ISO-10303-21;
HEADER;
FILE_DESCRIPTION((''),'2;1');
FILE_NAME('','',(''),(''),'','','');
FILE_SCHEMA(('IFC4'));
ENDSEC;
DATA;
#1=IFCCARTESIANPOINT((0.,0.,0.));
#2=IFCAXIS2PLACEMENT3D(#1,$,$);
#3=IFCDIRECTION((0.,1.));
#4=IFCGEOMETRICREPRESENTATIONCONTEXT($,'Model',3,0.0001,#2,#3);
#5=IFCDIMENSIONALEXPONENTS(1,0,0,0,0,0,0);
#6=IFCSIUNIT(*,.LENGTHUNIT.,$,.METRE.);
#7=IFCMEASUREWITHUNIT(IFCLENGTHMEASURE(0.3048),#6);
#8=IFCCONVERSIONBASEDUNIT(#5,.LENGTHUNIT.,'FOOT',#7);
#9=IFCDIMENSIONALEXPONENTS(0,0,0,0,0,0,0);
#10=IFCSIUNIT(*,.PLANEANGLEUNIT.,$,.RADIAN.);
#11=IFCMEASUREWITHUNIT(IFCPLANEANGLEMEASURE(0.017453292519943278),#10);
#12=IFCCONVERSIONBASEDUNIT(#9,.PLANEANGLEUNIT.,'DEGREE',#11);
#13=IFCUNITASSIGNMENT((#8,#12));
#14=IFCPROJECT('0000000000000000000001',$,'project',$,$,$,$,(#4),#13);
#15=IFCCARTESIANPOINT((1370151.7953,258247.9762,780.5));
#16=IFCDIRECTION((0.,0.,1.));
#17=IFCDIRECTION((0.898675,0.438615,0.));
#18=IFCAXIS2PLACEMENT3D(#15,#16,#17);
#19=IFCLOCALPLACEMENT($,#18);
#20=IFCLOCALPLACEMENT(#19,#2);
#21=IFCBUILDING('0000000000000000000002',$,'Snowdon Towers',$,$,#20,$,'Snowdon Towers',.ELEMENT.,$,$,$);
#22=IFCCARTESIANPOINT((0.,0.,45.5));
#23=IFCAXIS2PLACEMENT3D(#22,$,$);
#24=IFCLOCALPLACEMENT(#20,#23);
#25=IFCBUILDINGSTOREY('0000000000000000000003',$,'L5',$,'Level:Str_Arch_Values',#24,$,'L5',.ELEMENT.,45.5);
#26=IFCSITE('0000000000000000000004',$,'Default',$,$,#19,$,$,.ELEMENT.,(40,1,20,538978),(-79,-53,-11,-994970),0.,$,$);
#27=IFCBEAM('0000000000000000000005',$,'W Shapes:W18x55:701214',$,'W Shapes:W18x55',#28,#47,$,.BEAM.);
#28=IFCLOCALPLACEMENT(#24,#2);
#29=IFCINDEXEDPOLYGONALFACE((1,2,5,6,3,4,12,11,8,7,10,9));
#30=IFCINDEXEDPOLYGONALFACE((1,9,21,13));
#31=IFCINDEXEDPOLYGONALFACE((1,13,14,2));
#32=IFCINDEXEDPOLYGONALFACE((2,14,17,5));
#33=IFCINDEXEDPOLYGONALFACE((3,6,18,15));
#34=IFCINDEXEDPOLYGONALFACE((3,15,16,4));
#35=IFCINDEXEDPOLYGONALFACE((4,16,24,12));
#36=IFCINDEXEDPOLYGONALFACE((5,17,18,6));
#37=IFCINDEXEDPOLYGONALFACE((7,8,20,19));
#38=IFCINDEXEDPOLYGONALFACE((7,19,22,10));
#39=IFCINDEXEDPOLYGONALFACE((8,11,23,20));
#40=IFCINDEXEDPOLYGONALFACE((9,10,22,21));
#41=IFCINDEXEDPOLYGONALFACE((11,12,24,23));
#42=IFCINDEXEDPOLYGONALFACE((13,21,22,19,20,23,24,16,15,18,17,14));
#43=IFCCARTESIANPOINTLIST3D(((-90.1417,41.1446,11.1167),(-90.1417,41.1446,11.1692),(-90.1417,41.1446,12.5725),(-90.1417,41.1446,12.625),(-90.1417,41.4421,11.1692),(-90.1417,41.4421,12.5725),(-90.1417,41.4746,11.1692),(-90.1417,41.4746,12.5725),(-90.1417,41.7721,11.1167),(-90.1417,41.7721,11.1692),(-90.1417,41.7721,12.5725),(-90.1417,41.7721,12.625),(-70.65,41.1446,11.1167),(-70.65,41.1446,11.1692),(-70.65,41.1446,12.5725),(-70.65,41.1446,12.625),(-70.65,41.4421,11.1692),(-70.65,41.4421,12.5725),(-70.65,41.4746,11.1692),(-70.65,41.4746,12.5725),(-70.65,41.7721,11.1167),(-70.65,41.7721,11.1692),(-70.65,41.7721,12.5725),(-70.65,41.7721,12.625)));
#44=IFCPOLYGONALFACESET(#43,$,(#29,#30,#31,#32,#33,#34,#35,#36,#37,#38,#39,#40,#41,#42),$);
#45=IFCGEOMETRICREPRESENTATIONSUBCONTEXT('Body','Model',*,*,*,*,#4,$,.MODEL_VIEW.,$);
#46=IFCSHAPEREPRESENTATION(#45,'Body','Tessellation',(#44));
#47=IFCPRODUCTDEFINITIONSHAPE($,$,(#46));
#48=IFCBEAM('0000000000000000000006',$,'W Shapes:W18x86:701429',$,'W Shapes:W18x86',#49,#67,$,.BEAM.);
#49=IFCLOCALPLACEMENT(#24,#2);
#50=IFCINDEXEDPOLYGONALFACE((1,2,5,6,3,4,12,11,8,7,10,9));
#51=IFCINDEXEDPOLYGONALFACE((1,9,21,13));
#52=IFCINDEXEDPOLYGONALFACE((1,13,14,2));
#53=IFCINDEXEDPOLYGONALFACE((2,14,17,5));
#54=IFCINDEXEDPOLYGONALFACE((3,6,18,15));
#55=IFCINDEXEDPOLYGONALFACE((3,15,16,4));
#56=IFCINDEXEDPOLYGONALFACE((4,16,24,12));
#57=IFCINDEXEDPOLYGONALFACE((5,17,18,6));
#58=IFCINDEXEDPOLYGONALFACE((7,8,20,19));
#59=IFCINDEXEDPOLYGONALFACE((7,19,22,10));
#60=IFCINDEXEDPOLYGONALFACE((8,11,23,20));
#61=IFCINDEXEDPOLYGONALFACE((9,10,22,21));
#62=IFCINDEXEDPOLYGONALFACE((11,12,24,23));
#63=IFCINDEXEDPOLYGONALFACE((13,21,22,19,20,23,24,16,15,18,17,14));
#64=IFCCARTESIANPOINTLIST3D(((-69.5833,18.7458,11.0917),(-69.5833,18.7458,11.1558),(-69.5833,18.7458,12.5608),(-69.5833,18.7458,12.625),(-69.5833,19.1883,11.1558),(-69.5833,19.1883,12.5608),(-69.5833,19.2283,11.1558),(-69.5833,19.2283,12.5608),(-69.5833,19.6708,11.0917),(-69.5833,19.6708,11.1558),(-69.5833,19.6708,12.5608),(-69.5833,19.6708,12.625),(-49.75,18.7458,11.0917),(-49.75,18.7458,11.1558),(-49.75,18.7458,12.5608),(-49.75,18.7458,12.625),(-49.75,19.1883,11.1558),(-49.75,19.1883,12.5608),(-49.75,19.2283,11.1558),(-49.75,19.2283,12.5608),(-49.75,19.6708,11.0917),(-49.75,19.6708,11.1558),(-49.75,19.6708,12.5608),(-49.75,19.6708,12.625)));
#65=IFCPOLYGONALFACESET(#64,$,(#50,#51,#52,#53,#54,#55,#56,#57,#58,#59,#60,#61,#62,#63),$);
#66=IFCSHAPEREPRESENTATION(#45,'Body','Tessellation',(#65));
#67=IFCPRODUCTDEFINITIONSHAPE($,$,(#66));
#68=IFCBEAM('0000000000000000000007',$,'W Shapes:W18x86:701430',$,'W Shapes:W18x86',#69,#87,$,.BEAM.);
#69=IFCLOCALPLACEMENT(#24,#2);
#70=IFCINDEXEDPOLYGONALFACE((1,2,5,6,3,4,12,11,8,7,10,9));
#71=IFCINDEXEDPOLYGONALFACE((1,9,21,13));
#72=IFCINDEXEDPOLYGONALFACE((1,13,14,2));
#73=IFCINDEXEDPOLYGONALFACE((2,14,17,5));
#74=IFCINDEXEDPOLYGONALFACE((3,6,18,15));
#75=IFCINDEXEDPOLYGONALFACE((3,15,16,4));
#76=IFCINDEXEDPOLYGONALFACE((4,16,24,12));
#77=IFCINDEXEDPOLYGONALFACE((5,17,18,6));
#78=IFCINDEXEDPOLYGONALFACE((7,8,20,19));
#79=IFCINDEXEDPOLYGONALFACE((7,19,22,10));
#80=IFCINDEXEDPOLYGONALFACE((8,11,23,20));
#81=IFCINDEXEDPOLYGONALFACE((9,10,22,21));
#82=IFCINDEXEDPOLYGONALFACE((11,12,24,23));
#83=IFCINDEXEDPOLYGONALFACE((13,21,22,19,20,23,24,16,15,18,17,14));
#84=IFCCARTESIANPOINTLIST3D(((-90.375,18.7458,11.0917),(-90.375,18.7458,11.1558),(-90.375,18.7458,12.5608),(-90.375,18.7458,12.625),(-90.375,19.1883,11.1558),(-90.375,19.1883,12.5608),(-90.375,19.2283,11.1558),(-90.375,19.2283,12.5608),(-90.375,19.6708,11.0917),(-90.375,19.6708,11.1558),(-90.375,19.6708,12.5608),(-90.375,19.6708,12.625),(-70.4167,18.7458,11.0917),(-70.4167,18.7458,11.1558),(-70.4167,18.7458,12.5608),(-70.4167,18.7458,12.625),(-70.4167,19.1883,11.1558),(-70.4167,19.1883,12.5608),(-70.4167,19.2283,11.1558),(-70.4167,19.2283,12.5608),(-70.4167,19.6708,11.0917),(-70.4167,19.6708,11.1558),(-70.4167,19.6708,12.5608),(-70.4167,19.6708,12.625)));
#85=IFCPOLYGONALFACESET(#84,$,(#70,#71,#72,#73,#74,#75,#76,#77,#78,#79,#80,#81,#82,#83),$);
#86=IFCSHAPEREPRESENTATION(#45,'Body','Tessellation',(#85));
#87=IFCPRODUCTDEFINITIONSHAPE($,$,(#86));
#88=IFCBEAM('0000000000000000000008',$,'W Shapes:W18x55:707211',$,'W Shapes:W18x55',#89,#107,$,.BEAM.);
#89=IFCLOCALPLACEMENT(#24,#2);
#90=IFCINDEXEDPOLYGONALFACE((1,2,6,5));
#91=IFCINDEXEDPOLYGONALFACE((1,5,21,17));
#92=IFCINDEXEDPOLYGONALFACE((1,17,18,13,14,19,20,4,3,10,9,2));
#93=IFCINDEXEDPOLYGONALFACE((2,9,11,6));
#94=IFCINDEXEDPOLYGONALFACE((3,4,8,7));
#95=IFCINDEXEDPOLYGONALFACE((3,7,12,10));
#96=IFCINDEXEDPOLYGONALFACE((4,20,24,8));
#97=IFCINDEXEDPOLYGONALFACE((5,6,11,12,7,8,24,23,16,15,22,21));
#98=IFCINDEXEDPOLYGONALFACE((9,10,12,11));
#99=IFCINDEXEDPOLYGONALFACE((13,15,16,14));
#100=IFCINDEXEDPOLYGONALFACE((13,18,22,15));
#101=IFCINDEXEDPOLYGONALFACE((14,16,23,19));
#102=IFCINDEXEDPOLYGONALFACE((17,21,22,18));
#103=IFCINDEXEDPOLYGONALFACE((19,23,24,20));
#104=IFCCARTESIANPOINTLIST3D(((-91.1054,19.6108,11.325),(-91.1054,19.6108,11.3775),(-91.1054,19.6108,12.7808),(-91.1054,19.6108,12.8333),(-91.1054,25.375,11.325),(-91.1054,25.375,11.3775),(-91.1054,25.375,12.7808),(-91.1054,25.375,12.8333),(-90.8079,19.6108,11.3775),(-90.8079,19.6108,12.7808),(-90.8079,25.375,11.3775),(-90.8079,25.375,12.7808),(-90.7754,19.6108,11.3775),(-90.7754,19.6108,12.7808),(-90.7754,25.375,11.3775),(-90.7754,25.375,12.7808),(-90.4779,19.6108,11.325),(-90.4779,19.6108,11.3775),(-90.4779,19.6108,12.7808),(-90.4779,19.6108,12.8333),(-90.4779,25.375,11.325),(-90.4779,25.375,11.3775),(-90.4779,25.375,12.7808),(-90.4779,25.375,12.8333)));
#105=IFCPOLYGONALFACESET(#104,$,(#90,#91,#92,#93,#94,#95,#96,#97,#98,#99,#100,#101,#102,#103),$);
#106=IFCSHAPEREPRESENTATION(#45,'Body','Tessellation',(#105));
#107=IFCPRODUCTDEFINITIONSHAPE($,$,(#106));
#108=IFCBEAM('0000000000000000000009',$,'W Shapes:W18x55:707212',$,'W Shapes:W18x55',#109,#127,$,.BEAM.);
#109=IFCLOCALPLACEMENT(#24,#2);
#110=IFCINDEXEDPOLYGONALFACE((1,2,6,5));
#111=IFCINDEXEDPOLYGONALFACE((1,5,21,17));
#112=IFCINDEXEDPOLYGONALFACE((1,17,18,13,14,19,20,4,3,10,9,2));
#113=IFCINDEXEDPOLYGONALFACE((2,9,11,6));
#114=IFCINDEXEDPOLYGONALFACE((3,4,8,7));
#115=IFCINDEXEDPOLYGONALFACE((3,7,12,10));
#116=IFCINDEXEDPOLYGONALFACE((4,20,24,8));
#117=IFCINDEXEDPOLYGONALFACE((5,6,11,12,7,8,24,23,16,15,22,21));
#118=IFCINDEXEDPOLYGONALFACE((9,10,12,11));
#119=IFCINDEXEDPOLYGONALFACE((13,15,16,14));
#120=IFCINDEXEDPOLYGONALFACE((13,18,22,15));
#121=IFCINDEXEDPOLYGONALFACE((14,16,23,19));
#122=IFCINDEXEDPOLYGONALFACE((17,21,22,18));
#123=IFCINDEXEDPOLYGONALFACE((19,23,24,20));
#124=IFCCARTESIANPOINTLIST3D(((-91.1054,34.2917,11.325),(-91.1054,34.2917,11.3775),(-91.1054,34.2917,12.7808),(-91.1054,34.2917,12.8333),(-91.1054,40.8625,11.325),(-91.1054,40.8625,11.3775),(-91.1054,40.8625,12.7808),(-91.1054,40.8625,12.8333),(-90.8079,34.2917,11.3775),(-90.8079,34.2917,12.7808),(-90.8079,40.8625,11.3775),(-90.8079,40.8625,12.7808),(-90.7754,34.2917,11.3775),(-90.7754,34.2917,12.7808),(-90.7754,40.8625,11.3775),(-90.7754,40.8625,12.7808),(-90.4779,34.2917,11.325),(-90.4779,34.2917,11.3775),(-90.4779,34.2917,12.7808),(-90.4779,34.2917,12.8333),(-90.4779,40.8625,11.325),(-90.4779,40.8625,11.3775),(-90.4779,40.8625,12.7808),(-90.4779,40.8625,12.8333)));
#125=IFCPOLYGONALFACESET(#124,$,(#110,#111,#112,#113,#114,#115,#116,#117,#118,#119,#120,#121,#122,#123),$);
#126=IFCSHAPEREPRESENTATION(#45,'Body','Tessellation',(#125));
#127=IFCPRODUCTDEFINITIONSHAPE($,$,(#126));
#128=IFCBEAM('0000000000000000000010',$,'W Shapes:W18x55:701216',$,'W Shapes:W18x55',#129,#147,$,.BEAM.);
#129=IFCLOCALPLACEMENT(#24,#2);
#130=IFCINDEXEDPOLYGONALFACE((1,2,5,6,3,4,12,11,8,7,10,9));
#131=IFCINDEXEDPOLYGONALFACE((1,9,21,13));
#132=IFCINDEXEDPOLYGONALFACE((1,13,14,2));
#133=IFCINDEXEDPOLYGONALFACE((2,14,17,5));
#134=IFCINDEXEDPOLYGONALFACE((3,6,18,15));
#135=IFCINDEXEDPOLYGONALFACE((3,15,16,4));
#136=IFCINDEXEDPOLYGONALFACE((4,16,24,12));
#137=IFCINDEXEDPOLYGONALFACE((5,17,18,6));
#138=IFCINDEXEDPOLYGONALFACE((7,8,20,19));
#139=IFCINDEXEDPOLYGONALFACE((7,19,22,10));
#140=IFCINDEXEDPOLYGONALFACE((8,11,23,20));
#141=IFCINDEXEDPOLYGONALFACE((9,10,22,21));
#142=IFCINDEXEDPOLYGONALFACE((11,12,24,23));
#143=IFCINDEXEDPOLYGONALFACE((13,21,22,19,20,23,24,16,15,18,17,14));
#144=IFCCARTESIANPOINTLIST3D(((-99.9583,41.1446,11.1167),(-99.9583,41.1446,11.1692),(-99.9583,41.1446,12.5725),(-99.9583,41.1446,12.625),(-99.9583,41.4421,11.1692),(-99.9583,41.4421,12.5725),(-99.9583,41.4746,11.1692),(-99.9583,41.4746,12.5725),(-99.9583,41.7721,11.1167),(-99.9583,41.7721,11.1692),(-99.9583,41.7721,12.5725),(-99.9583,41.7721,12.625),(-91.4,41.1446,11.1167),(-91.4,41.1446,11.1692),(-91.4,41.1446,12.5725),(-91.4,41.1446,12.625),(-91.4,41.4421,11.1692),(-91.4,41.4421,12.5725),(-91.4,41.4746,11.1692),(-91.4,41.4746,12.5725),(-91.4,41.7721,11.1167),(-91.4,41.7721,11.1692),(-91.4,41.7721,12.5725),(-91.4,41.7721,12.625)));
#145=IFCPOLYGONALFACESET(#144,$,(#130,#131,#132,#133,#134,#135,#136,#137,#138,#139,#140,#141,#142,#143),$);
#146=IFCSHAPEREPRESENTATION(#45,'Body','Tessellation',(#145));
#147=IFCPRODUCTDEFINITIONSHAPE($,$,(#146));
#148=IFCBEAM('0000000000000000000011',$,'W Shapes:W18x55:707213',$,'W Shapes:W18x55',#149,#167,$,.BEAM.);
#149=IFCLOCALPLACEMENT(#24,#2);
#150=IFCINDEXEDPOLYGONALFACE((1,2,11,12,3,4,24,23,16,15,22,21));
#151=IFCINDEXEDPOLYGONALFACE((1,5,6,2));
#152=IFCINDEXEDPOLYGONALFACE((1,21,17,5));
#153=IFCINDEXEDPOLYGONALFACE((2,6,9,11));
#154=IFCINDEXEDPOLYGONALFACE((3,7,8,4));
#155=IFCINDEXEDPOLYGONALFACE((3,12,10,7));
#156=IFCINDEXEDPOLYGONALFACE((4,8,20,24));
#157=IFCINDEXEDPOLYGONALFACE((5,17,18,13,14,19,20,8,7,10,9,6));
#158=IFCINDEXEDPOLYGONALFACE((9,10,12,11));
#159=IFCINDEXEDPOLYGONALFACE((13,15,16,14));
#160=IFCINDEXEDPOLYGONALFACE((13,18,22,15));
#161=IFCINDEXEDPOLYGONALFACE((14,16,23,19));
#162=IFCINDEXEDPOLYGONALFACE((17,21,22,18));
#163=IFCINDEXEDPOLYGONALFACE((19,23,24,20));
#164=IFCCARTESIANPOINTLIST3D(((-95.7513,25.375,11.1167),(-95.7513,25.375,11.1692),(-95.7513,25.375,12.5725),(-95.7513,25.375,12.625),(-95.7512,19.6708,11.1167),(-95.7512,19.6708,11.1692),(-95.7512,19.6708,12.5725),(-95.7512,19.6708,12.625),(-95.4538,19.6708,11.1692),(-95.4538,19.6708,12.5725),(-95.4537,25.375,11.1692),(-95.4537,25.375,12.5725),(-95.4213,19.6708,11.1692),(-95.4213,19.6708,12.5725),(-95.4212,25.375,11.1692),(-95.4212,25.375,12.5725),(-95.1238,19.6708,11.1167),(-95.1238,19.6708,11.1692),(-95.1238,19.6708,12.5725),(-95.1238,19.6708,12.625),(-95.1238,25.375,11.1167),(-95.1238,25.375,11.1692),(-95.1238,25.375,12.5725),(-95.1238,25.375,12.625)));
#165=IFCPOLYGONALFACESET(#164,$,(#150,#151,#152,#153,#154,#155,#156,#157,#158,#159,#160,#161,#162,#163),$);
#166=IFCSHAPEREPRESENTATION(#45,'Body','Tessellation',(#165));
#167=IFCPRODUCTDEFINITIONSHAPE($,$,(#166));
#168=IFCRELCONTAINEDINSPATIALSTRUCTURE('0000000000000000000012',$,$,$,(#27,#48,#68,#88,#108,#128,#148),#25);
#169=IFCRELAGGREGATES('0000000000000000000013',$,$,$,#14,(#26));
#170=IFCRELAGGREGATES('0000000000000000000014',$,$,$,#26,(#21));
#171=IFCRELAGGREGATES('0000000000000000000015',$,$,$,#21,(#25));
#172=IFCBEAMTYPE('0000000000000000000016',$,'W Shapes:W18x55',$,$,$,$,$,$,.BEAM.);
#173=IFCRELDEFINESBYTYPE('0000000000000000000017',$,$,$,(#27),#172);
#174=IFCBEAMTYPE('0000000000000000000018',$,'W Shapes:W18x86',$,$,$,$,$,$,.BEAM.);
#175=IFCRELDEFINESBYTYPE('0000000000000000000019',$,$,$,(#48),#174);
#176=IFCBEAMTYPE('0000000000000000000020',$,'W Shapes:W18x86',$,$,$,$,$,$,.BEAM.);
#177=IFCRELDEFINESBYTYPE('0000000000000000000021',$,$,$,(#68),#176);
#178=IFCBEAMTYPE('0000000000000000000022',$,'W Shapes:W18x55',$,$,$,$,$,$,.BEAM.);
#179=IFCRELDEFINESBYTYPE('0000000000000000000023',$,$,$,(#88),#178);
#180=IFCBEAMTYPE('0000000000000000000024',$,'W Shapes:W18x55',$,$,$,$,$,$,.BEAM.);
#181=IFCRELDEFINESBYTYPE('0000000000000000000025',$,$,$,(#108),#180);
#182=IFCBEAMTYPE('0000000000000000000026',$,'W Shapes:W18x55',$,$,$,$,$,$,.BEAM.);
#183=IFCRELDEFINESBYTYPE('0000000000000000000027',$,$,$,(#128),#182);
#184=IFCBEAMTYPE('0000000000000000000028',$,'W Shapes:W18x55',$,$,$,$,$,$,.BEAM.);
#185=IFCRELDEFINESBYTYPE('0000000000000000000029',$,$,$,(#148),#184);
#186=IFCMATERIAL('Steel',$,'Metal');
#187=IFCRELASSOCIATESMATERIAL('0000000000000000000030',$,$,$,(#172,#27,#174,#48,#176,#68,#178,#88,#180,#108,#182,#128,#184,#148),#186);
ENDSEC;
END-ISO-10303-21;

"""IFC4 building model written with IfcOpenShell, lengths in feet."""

from ifc_helpers import new_model, entity, si_unit, converted_unit, direction, frame, origin, place, context, subcontext, project, spatial, indexed_curve, outline, extrude, source, transform, mapped, material, type_object, type_shapes, element, save


model = new_model("IFC4")

# Units and contexts
model_context = context("Model", 3, precision=0.0001, world=origin(), true_north=direction((0.0, 1.0)))
body_context = subcontext(model_context, "Body", "Model", "MODEL_VIEW")
ifc_project = project(units=[converted_unit("LENGTHUNIT", "FOOT", entity("IfcLengthMeasure", 0.3048), si_unit("LENGTHUNIT", "METRE"), dimensions=[1, 0, 0, 0, 0, 0, 0]), converted_unit("PLANEANGLEUNIT", "DEGREE", entity("IfcPlaneAngleMeasure", 0.017453292519943278), si_unit("PLANEANGLEUNIT", "RADIAN"), dimensions=[0, 0, 0, 0, 0, 0, 0])], contexts=[model_context])

# Site, building, storey
site_placement = place(None, frame((1370151.7953, 258247.9762, 780.5), z_axis=(0.0, 0.0, 1.0), x_axis=(0.898675, 0.438615, 0.0)))
site = spatial("IfcSite", under=ifc_project, at=site_placement, Name="Default", CompositionType="ELEMENT", RefLatitude=(40, 1, 20, 538978), RefLongitude=(-79, -53, -11, -994970), RefElevation=0.0)
building_placement = place(site_placement, origin())
building = spatial("IfcBuilding", under=site, at=building_placement, Name="Snowdon Towers", LongName="Snowdon Towers", CompositionType="ELEMENT")
storey_placement = place(building_placement, frame((0.0, 0.0, 45.5)))
storey = spatial("IfcBuildingStorey", under=building, at=storey_placement, Name="L5", ObjectType="Level:Str_Arch_Values", LongName="L5", CompositionType="ELEMENT", Elevation=45.5)

# Beams
ifc_material = material(Name="Steel", Category="Metal")
beam_type_1 = type_object("IfcBeamType", Name="W Shapes:W18x55", PredefinedType="BEAM", material=ifc_material)
shared_shape_1 = source(origin(), body_context, "Body", "SweptSolid", [
    extrude(outline(indexed_curve([(-0.3138, -0.7017), (-0.3138, -0.7542), (0.3138, -0.7542), (0.3138, -0.7017), (0.0162, -0.7017), (0.0162, 0.7017), (0.3138, 0.7017), (0.3138, 0.7542), (-0.3137, 0.7542), (-0.3137, 0.7017), (-0.0163, 0.7017), (-0.0163, -0.7017), (-0.3138, -0.7017)], self_intersect=False)), frame((-9.7875, 0.0, 0.0), z_axis=(-1.0, 0.0, 0.0), x_axis=(0.0, -1.0, 0.0)), (0.0, 0.0, -1.0), 19.4917),
])
type_shapes(beam_type_1, [shared_shape_1])
beam_1_placement = place(storey_placement, frame((-80.3542, 41.4583, 11.8708)))
element("IfcBeam", 1, at=beam_1_placement, inside=storey, type_object=beam_type_1, material=ifc_material, Name="W Shapes:W18x55:701214", ObjectType="W Shapes:W18x55", PredefinedType="BEAM", context=body_context, shape_type="MappedRepresentation", body=[
    mapped(shared_shape_1, transform((0.0, 0.0, 0.0), scale=1.0)),
])
beam_type_2 = type_object("IfcBeamType", Name="W Shapes:W18x86", PredefinedType="BEAM", material=ifc_material)
shared_shape_2 = source(origin(), body_context, "Body", "SweptSolid", [
    extrude(outline(indexed_curve([(-0.4625, -0.7025), (-0.4625, -0.7667), (0.4625, -0.7667), (0.4625, -0.7025), (0.02, -0.7025), (0.02, 0.7025), (0.4625, 0.7025), (0.4625, 0.7667), (-0.4625, 0.7667), (-0.4625, 0.7025), (-0.02, 0.7025), (-0.02, -0.7025), (-0.4625, -0.7025)], self_intersect=False)), frame((-9.9583, 0.0, 0.0), z_axis=(-1.0, 0.0, 0.0), x_axis=(0.0, -1.0, 0.0)), (0.0, 0.0, -1.0), 19.8333),
])
type_shapes(beam_type_2, [shared_shape_2])
beam_2_placement = place(storey_placement, frame((-59.625, 19.2083, 11.8583)))
element("IfcBeam", 2, at=beam_2_placement, inside=storey, type_object=beam_type_2, material=ifc_material, Name="W Shapes:W18x86:701429", ObjectType="W Shapes:W18x86", PredefinedType="BEAM", context=body_context, shape_type="MappedRepresentation", body=[
    mapped(shared_shape_2, transform((0.0, 0.0, 0.0), scale=1.0)),
])
beam_type_3 = type_object("IfcBeamType", Name="W Shapes:W18x86", PredefinedType="BEAM", material=ifc_material)
shared_shape_3 = source(origin(), body_context, "Body", "SweptSolid", [
    extrude(outline(indexed_curve([(-0.4625, -0.7025), (-0.4625, -0.7667), (0.4625, -0.7667), (0.4625, -0.7025), (0.02, -0.7025), (0.02, 0.7025), (0.4625, 0.7025), (0.4625, 0.7667), (-0.4625, 0.7667), (-0.4625, 0.7025), (-0.02, 0.7025), (-0.02, -0.7025), (-0.4625, -0.7025)], self_intersect=False)), frame((-10.0, 0.0, 0.0), z_axis=(-1.0, 0.0, 0.0), x_axis=(0.0, -1.0, 0.0)), (0.0, 0.0, -1.0), 19.9583),
])
type_shapes(beam_type_3, [shared_shape_3])
beam_3_placement = place(storey_placement, frame((-80.375, 19.2083, 11.8583)))
element("IfcBeam", 3, at=beam_3_placement, inside=storey, type_object=beam_type_3, material=ifc_material, Name="W Shapes:W18x86:701430", ObjectType="W Shapes:W18x86", PredefinedType="BEAM", context=body_context, shape_type="MappedRepresentation", body=[
    mapped(shared_shape_3, transform((0.0, 0.0, 0.0), scale=1.0)),
])
beam_type_4 = type_object("IfcBeamType", Name="W Shapes:W18x55", PredefinedType="BEAM", material=ifc_material)
shared_shape_4 = source(origin(), body_context, "Body", "SweptSolid", [
    extrude(outline(indexed_curve([(-0.3138, -0.7017), (-0.3138, -0.7542), (0.3138, -0.7542), (0.3138, -0.7017), (0.0162, -0.7017), (0.0162, 0.7017), (0.3138, 0.7017), (0.3138, 0.7542), (-0.3137, 0.7542), (-0.3137, 0.7017), (-0.0163, 0.7017), (-0.0163, -0.7017), (-0.3138, -0.7017)], self_intersect=False)), frame((-2.6737, 0.0, 0.0), z_axis=(-1.0, 0.0, 0.0), x_axis=(0.0, -1.0, 0.0)), (0.0, 0.0, -1.0), 5.7642),
])
type_shapes(beam_type_4, [shared_shape_4])
beam_4_placement = place(storey_placement, frame((-90.7917, 22.2846, 12.0792), z_axis=(0.0, 0.0, 1.0), x_axis=(0.0, 1.0, 0.0)))
element("IfcBeam", 4, at=beam_4_placement, inside=storey, type_object=beam_type_4, material=ifc_material, Name="W Shapes:W18x55:707211", ObjectType="W Shapes:W18x55", PredefinedType="BEAM", context=body_context, shape_type="MappedRepresentation", body=[
    mapped(shared_shape_4, transform((0.0, 0.0, 0.0), scale=1.0)),
])
beam_type_5 = type_object("IfcBeamType", Name="W Shapes:W18x55", PredefinedType="BEAM", material=ifc_material)
shared_shape_5 = source(origin(), body_context, "Body", "SweptSolid", [
    extrude(outline(indexed_curve([(-0.3138, -0.7017), (-0.3138, -0.7542), (0.3138, -0.7542), (0.3138, -0.7017), (0.0162, -0.7017), (0.0162, 0.7017), (0.3138, 0.7017), (0.3138, 0.7542), (-0.3137, 0.7542), (-0.3137, 0.7017), (-0.0163, 0.7017), (-0.0163, -0.7017), (-0.3138, -0.7017)], self_intersect=False)), frame((-3.1958, 0.0, 0.0), z_axis=(-1.0, 0.0, 0.0), x_axis=(0.0, -1.0, 0.0)), (0.0, 0.0, -1.0), 6.5708),
])
type_shapes(beam_type_5, [shared_shape_5])
beam_5_placement = place(storey_placement, frame((-90.7917, 37.6667, 12.0792), z_axis=(0.0, 0.0, 1.0), x_axis=(0.0, -1.0, 0.0)))
element("IfcBeam", 5, at=beam_5_placement, inside=storey, type_object=beam_type_5, material=ifc_material, Name="W Shapes:W18x55:707212", ObjectType="W Shapes:W18x55", PredefinedType="BEAM", context=body_context, shape_type="MappedRepresentation", body=[
    mapped(shared_shape_5, transform((0.0, 0.0, 0.0), scale=1.0)),
])
beam_type_6 = type_object("IfcBeamType", Name="W Shapes:W18x55", PredefinedType="BEAM", material=ifc_material)
shared_shape_6 = source(origin(), body_context, "Body", "SweptSolid", [
    extrude(outline(indexed_curve([(-0.3138, -0.7017), (-0.3138, -0.7542), (0.3138, -0.7542), (0.3138, -0.7017), (0.0162, -0.7017), (0.0162, 0.7017), (0.3138, 0.7017), (0.3138, 0.7542), (-0.3137, 0.7542), (-0.3137, 0.7017), (-0.0163, 0.7017), (-0.0163, -0.7017), (-0.3138, -0.7017)], self_intersect=False)), frame((-4.6042, 0.0, 0.0), z_axis=(-1.0, 0.0, 0.0), x_axis=(0.0, -1.0, 0.0)), (0.0, 0.0, -1.0), 8.5583),
])
type_shapes(beam_type_6, [shared_shape_6])
beam_6_placement = place(storey_placement, frame((-95.3542, 41.4583, 11.8708)))
element("IfcBeam", 6, at=beam_6_placement, inside=storey, type_object=beam_type_6, material=ifc_material, Name="W Shapes:W18x55:701216", ObjectType="W Shapes:W18x55", PredefinedType="BEAM", context=body_context, shape_type="MappedRepresentation", body=[
    mapped(shared_shape_6, transform((0.0, 0.0, 0.0), scale=1.0)),
])
beam_type_7 = type_object("IfcBeamType", Name="W Shapes:W18x55", PredefinedType="BEAM", material=ifc_material)
shared_shape_7 = source(origin(), body_context, "Body", "SweptSolid", [
    extrude(outline(indexed_curve([(-0.3138, -0.7017), (-0.3138, -0.7542), (0.3138, -0.7542), (0.3138, -0.7017), (0.0162, -0.7017), (0.0162, 0.7017), (0.3138, 0.7017), (0.3138, 0.7542), (-0.3137, 0.7542), (-0.3137, 0.7017), (-0.0163, 0.7017), (-0.0163, -0.7017), (-0.3138, -0.7017)], self_intersect=False)), frame((-2.6208, 0.0, 0.0), z_axis=(-1.0, 0.0, 0.0), x_axis=(0.0, -1.0, 0.0)), (0.0, 0.0, -1.0), 5.7042),
])
type_shapes(beam_type_7, [shared_shape_7])
beam_7_placement = place(storey_placement, frame((-95.4375, 22.2917, 11.8708), z_axis=(0.0, 0.0, 1.0), x_axis=(0.0, 1.0, 0.0)))
element("IfcBeam", 7, at=beam_7_placement, inside=storey, type_object=beam_type_7, material=ifc_material, Name="W Shapes:W18x55:707213", ObjectType="W Shapes:W18x55", PredefinedType="BEAM", context=body_context, shape_type="MappedRepresentation", body=[
    mapped(shared_shape_7, transform((0.0, 0.0, 0.0), scale=1.0)),
])

save(model, "model.ifc")
